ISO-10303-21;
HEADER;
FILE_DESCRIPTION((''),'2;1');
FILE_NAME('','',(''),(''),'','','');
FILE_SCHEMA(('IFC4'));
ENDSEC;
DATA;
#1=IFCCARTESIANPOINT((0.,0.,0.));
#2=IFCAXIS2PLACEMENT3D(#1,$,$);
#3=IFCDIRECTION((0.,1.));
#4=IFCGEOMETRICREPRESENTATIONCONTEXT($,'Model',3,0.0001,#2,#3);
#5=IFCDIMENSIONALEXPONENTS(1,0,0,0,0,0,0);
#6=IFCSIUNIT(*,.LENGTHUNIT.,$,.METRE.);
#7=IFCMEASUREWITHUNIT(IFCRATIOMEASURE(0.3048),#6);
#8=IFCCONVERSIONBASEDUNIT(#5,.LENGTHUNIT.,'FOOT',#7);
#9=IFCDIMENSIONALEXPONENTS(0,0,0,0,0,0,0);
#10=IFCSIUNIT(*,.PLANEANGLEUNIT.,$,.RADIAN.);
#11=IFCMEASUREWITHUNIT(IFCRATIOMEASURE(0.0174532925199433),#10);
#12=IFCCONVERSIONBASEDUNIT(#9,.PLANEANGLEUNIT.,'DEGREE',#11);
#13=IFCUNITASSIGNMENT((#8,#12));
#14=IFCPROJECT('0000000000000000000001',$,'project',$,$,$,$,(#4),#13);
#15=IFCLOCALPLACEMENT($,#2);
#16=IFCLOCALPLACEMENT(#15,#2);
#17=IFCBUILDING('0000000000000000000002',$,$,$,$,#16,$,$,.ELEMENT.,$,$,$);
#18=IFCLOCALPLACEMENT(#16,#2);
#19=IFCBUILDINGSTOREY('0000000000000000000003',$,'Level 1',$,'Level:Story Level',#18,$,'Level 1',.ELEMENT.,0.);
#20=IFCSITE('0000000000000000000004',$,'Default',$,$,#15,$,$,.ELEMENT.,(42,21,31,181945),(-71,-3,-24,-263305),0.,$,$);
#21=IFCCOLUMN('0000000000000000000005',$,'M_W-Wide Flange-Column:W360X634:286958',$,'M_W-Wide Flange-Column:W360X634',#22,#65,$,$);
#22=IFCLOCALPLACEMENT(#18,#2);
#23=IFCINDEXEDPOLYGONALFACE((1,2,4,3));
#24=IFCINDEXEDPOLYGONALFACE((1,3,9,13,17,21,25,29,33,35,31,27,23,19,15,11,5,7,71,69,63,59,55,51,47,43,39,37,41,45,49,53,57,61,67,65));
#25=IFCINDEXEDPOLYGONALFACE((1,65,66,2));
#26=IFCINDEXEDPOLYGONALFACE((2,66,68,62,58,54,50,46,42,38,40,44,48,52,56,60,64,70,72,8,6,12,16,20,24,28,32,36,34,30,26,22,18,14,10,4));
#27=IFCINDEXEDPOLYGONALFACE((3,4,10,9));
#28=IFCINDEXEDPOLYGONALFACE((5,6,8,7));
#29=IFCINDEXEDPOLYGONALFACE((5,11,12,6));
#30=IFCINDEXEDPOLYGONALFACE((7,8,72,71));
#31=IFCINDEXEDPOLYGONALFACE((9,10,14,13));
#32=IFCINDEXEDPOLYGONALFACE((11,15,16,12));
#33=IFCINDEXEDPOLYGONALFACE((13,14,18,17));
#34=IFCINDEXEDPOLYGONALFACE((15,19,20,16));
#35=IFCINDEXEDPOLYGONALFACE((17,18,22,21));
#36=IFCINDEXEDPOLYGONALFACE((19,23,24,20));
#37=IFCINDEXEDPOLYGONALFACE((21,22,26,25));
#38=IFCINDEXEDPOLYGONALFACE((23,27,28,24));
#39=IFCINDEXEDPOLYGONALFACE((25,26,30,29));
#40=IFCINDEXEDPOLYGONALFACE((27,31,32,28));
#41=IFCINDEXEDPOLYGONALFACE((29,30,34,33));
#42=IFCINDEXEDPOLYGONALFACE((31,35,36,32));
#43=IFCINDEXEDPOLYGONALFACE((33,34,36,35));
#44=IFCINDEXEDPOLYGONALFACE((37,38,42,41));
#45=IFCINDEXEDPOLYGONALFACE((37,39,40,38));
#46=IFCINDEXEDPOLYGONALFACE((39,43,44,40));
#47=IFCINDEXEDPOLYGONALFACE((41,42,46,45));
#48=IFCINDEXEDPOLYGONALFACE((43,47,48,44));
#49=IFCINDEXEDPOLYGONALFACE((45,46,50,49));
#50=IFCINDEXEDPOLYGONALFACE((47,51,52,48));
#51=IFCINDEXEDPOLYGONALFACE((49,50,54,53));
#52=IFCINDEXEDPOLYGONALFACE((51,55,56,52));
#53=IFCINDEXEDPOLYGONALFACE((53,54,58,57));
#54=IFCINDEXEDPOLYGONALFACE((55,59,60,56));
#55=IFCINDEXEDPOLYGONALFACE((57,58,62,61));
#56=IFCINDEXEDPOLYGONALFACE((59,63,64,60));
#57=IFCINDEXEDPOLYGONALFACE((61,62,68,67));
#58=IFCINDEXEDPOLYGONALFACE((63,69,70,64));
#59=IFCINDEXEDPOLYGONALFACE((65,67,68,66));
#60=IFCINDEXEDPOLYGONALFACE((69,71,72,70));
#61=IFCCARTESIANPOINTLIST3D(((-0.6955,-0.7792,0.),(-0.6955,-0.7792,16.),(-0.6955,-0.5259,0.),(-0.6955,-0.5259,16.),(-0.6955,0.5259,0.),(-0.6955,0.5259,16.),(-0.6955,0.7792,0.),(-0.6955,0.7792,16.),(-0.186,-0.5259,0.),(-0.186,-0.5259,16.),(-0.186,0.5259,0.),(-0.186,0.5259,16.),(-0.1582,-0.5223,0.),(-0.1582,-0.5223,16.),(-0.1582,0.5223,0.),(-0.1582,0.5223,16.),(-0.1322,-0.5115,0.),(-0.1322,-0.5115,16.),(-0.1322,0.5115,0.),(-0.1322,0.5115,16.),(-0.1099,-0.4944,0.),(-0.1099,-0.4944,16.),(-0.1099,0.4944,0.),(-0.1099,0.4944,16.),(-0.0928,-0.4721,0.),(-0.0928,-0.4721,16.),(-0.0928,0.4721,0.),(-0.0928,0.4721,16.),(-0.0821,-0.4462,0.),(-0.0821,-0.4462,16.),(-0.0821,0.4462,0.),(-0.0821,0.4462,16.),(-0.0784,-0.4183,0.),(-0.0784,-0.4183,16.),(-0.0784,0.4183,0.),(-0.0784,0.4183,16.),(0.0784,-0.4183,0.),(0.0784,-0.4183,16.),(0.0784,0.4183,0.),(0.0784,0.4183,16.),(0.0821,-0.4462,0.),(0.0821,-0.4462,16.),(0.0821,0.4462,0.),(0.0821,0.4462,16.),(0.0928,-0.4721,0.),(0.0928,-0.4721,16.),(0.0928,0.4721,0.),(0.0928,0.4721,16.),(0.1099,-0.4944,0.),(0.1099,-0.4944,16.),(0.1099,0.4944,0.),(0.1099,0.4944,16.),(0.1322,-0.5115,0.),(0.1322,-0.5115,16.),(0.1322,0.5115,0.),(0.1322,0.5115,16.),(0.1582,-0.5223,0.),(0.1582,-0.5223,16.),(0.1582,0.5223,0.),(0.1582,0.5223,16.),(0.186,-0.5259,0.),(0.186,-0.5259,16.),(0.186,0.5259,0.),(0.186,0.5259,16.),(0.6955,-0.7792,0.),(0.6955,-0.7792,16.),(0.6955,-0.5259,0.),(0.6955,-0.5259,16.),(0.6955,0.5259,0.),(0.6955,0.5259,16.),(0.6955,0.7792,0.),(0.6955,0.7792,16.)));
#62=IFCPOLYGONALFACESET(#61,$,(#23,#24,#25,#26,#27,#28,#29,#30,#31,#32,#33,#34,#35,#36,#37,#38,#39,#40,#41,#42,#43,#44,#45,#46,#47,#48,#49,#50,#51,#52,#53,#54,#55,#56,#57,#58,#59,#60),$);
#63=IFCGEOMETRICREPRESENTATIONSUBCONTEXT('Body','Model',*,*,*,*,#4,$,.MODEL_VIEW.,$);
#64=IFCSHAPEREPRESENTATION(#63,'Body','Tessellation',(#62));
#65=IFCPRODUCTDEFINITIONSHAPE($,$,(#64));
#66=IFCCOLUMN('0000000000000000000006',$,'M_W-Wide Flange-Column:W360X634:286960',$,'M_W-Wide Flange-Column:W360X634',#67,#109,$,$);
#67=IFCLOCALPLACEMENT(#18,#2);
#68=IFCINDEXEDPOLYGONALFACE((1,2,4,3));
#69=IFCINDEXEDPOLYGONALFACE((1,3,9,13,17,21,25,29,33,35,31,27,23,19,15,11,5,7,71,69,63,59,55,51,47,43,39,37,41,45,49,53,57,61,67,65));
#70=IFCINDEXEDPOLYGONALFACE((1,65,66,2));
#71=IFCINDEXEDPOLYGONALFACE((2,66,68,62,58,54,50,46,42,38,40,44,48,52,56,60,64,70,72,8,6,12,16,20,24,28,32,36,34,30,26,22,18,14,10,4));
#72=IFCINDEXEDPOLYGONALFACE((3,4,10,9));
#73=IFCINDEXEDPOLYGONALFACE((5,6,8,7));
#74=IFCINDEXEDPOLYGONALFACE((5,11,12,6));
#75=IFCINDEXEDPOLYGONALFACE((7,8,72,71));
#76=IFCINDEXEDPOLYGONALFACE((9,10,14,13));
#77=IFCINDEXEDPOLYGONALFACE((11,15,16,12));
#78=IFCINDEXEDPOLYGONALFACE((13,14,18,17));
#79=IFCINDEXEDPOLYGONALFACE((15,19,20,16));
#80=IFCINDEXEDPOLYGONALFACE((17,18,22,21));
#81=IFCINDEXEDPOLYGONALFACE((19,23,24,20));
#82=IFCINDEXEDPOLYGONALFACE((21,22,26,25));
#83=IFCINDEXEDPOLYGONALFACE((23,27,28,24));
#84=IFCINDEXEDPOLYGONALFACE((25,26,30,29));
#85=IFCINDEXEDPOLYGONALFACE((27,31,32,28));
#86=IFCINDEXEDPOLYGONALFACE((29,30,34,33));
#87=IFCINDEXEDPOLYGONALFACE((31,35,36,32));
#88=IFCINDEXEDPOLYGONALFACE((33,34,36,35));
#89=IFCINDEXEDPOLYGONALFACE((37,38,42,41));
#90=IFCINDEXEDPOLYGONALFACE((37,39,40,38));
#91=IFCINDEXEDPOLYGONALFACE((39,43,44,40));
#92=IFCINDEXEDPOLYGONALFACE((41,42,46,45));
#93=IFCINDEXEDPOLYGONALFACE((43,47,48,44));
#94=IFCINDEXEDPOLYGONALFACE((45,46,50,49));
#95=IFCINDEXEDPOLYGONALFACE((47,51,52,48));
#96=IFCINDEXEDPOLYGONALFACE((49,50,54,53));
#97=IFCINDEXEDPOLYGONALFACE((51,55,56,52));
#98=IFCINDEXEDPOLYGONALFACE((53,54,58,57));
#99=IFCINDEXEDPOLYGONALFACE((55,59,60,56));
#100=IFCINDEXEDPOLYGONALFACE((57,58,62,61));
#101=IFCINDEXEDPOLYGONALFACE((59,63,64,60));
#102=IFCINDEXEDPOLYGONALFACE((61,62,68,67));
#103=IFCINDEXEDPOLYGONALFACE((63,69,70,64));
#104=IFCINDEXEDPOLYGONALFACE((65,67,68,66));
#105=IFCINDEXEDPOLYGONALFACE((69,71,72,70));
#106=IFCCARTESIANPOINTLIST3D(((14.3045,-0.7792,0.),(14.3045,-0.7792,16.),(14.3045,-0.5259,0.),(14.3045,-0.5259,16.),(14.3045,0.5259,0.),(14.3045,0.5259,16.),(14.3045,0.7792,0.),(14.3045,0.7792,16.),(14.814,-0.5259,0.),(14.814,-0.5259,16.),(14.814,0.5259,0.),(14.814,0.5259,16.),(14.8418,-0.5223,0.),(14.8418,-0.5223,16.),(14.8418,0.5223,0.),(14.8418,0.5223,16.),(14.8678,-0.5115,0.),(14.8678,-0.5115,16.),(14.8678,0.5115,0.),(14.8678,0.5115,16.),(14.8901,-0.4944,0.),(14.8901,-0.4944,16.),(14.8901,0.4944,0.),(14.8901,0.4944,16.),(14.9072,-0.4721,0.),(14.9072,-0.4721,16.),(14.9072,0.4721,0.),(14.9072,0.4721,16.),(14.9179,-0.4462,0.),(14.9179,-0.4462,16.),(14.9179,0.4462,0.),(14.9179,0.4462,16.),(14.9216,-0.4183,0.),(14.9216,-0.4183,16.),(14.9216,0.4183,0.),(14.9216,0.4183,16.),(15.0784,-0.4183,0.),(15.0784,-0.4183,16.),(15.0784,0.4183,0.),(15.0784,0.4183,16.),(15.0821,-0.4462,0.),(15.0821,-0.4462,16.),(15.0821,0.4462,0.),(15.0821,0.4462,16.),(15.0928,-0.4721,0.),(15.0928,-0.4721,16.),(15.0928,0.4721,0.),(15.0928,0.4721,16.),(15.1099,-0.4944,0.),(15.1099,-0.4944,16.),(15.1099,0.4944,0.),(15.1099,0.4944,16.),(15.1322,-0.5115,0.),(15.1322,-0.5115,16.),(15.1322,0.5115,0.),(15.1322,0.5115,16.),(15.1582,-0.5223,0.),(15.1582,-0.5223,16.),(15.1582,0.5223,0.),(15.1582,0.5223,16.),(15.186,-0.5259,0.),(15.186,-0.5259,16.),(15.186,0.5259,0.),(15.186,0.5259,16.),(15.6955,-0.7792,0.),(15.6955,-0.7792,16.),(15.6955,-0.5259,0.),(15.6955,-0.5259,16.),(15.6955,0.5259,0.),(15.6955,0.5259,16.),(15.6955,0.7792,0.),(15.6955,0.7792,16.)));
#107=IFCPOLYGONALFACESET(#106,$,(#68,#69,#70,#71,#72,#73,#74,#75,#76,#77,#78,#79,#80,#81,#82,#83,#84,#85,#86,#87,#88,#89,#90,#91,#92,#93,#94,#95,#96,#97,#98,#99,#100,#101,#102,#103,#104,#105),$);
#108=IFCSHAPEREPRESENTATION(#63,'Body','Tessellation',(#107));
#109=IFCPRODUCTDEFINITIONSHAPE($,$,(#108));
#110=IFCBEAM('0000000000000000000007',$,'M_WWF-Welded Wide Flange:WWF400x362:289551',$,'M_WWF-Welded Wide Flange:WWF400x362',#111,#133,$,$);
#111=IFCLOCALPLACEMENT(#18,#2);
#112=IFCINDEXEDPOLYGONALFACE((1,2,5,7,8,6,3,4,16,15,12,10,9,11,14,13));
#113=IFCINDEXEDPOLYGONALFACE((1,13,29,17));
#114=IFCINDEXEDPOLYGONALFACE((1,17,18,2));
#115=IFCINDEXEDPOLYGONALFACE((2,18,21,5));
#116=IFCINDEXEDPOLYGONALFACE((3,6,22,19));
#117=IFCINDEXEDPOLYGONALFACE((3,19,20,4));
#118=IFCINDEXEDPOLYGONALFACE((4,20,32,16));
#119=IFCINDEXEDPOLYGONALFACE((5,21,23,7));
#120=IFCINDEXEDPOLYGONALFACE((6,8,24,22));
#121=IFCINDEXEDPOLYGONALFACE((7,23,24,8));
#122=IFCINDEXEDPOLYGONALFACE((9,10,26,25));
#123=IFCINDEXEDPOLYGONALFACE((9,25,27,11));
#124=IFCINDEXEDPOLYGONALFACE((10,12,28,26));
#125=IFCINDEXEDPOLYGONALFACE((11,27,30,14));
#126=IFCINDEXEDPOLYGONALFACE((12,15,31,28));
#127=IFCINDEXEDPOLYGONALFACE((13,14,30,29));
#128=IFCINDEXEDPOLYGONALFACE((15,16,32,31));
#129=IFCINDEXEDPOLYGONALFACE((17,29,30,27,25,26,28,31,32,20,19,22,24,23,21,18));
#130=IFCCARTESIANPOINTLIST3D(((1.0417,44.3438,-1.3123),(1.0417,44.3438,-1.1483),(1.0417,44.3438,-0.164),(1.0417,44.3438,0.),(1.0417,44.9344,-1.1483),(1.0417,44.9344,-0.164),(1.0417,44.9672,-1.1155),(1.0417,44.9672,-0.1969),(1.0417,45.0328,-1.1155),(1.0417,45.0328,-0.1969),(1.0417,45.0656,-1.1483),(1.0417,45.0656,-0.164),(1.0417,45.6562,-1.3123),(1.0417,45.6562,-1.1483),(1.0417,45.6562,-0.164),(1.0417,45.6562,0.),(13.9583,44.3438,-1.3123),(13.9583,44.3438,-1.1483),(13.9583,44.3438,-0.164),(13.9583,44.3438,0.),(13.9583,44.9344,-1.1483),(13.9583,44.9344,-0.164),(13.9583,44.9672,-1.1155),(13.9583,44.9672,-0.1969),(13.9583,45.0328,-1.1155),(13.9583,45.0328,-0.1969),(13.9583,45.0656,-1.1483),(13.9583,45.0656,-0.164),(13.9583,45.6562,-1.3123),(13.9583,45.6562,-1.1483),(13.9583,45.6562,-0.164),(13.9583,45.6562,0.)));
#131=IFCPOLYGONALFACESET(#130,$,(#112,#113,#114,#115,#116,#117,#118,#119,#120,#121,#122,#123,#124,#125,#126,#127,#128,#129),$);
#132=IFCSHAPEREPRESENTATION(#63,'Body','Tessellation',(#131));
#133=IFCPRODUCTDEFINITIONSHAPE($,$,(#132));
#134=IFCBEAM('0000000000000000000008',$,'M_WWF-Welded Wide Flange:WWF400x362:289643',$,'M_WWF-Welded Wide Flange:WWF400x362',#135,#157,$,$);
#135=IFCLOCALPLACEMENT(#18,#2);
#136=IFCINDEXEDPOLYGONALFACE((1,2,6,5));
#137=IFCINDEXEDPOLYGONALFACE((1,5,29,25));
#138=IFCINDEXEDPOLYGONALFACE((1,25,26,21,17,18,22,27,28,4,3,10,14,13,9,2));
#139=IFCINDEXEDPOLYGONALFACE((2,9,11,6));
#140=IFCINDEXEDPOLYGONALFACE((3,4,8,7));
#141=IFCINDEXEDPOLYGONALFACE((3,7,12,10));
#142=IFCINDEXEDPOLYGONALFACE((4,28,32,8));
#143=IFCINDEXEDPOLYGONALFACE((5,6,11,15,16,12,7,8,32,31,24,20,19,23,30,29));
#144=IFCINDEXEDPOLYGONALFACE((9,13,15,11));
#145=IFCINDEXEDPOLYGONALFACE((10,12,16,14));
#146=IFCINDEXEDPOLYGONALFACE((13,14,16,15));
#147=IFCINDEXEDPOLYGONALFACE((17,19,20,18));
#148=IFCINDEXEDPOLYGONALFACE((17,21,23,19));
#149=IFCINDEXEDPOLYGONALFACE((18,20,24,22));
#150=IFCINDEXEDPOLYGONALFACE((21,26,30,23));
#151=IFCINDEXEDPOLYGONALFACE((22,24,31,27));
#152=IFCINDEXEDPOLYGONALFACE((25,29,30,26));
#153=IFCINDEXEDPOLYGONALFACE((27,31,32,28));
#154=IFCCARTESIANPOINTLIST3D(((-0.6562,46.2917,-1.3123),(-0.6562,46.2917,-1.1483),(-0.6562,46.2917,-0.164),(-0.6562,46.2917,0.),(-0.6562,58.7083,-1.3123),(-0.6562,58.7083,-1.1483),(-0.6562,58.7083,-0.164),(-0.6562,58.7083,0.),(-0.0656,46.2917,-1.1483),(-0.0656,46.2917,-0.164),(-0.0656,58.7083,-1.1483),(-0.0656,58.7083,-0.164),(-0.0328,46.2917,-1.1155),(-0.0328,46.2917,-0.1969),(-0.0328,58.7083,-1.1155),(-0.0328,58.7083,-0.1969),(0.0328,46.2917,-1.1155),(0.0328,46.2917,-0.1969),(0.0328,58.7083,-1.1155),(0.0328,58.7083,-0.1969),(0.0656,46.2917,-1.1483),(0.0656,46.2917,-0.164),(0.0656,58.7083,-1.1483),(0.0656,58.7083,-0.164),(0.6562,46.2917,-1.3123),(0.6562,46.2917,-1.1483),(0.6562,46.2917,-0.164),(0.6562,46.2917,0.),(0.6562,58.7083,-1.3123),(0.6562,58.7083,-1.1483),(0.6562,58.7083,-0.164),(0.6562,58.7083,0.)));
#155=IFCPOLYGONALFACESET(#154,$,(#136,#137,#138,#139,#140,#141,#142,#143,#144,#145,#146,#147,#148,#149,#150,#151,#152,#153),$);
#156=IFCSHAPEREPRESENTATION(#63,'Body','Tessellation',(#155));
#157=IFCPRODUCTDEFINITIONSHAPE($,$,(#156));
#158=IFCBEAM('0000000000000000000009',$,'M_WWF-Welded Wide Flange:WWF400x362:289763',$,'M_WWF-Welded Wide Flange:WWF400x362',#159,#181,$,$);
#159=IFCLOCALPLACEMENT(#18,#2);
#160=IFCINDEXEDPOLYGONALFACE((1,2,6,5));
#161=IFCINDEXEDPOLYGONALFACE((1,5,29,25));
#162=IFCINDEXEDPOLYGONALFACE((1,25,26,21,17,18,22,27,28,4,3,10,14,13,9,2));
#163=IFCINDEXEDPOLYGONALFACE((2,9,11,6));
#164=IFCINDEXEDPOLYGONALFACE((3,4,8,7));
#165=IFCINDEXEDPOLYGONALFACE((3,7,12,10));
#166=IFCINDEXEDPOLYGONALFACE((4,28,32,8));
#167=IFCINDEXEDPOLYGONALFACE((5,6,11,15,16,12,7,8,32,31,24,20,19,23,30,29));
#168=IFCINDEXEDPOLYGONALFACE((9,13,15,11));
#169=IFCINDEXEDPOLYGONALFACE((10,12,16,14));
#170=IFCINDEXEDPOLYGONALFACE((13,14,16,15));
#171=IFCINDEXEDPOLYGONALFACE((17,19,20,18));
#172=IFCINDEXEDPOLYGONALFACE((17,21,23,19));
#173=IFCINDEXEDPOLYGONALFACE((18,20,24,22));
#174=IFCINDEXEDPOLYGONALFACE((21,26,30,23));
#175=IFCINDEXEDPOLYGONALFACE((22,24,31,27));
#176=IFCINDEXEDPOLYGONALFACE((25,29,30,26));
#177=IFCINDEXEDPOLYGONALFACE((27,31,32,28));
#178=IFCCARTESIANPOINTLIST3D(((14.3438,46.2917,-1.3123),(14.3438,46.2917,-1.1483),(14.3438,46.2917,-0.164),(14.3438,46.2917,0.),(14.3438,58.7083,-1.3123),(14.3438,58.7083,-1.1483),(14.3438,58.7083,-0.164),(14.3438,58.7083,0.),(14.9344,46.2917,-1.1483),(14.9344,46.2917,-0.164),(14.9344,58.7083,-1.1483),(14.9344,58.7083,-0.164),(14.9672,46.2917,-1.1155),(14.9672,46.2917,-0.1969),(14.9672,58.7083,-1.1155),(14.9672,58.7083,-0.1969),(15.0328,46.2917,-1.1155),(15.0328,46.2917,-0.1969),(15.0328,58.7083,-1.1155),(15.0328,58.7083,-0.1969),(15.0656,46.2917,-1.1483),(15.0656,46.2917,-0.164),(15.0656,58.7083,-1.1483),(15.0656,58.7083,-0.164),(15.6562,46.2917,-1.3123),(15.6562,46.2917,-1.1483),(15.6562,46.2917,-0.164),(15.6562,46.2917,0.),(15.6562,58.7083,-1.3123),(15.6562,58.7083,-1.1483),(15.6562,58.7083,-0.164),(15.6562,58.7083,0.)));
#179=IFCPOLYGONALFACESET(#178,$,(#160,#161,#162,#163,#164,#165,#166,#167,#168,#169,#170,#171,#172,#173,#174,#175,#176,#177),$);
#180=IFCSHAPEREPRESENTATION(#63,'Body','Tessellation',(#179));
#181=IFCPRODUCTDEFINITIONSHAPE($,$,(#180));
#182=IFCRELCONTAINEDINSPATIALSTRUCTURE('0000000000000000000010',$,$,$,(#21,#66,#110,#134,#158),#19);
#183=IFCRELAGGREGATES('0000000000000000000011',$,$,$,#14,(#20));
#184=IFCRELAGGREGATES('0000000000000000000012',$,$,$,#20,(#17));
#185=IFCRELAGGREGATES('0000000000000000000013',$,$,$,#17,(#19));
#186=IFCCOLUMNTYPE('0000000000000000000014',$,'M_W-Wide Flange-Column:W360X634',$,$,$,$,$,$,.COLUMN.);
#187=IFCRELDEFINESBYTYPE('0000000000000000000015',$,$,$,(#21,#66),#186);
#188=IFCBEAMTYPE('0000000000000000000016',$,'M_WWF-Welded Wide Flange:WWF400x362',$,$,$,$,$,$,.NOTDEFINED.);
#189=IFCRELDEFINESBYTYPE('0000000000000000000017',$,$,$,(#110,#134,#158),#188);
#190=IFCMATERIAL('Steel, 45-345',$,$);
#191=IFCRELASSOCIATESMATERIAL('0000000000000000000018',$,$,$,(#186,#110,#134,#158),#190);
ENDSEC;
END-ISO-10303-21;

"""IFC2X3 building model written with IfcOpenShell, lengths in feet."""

from ifc_helpers import new_model, entity, si_unit, converted_unit, direction, frame, frame_2d, origin, place, context, subcontext, project, spatial, polyline, circle_curve, parameter, trimmed, segment, composite_curve, outline, extrude, source, transform, mapped, material, type_object, type_shapes, element, save


model = new_model("IFC2X3")

# Units and contexts
model_context = context("Model", 3, precision=0.0001, world=origin(), true_north=direction((0.0, 1.0)))
body_context = subcontext(model_context, "Body", "Model", "MODEL_VIEW")
ifc_project = project(units=[converted_unit("LENGTHUNIT", "FOOT", entity("IfcRatioMeasure", 0.3048), si_unit("LENGTHUNIT", "METRE"), dimensions=[1, 0, 0, 0, 0, 0, 0]), converted_unit("PLANEANGLEUNIT", "DEGREE", entity("IfcRatioMeasure", 0.0174532925199433), si_unit("PLANEANGLEUNIT", "RADIAN"), dimensions=[0, 0, 0, 0, 0, 0, 0])], contexts=[model_context])

# Site, building, storey
site_placement = place(None, origin())
site = spatial("IfcSite", under=ifc_project, at=site_placement, Name="Default", CompositionType="ELEMENT", RefLatitude=(42, 21, 31, 181945), RefLongitude=(-71, -3, -24, -263305), RefElevation=0.0)
building_placement = place(site_placement, origin())
building = spatial("IfcBuilding", under=site, at=building_placement, CompositionType="ELEMENT")
storey_placement = place(building_placement, origin())
storey = spatial("IfcBuildingStorey", under=building, at=storey_placement, Name="Level 1", ObjectType="Level:Story Level", LongName="Level 1", CompositionType="ELEMENT", Elevation=0.0)

# Columns
ifc_material = material(Name="Steel, 45-345")
column_type = type_object("IfcColumnType", Name="M_W-Wide Flange-Column:W360X634", PredefinedType="COLUMN", material=ifc_material)
shared_shape = source(origin(), body_context, "Body", "SweptSolid", [
    extrude(outline(composite_curve([segment(polyline([(0.5259, -0.6955), (0.7792, -0.6955)]), True, "CONTINUOUS"), segment(polyline([(0.7792, -0.6955), (0.7792, 0.6955)]), True, "CONTINUOUS"), segment(polyline([(0.7792, 0.6955), (0.5259, 0.6955)]), True, "CONTINUOUS"), segment(polyline([(0.5259, 0.6955), (0.5259, 0.186)]), True, "CONTINUOUS"), segment(trimmed(circle_curve(frame_2d((0.4183, 0.186), x_axis=(1.0, 0.0)), 0.1076), [parameter(270.0)], [parameter(0.0)], True, "PARAMETER"), False, "CONTINUOUS"), segment(polyline([(0.4183, 0.0784), (-0.4183, 0.0784)]), True, "CONTINUOUS"), segment(trimmed(circle_curve(frame_2d((-0.4183, 0.186), x_axis=(0.0, -1.0)), 0.1076), [parameter(270.0)], [parameter(0.0)], True, "PARAMETER"), False, "CONTINUOUS"), segment(polyline([(-0.5259, 0.186), (-0.5259, 0.6955)]), True, "CONTINUOUS"), segment(polyline([(-0.5259, 0.6955), (-0.7792, 0.6955)]), True, "CONTINUOUS"), segment(polyline([(-0.7792, 0.6955), (-0.7792, -0.6955)]), True, "CONTINUOUS"), segment(polyline([(-0.7792, -0.6955), (-0.5259, -0.6955)]), True, "CONTINUOUS"), segment(polyline([(-0.5259, -0.6955), (-0.5259, -0.186)]), True, "CONTINUOUS"), segment(trimmed(circle_curve(frame_2d((-0.4183, -0.186), x_axis=(-1.0, 0.0)), 0.1076), [parameter(270.0)], [parameter(0.0)], True, "PARAMETER"), False, "CONTINUOUS"), segment(polyline([(-0.4183, -0.0784), (0.4183, -0.0784)]), True, "CONTINUOUS"), segment(trimmed(circle_curve(frame_2d((0.4183, -0.186), x_axis=(0.0, 1.0)), 0.1076), [parameter(270.0)], [parameter(0.0)], True, "PARAMETER"), False, "CONTINUOUS"), segment(polyline([(0.5259, -0.186), (0.5259, -0.6955)]), True, "CONTINUOUS")], self_intersect=False)), frame((0.0, 0.0, 0.0), z_axis=(0.0, 0.0, 1.0), x_axis=(0.0, -1.0, 0.0)), (0.0, 0.0, 1.0), 16.0),
])
type_shapes(column_type, [shared_shape])
for number, where, name in (
    (1, (0.0, 0.0, 0.0), "M_W-Wide Flange-Column:W360X634:286958"),
    (2, (15.0, 0.0, 0.0), "M_W-Wide Flange-Column:W360X634:286960"),
):
    element("IfcColumn", number, at=place(storey_placement, frame(where)), inside=storey, type_object=column_type, Name=name, ObjectType="M_W-Wide Flange-Column:W360X634", context=body_context, shape_type="MappedRepresentation", body=[
        mapped(shared_shape, transform((0.0, 0.0, 0.0), scale=1.0)),
    ])

# Beams
beam_type = type_object("IfcBeamType", Name="M_WWF-Welded Wide Flange:WWF400x362", PredefinedType="NOTDEFINED")
beam_1_placement = place(storey_placement, frame((0.0, 45.0, 0.0)))
element("IfcBeam", 3, at=beam_1_placement, inside=storey, type_object=beam_type, material=ifc_material, Name="M_WWF-Welded Wide Flange:WWF400x362:289551", ObjectType="M_WWF-Welded Wide Flange:WWF400x362", context=body_context, shape_type="SweptSolid", body=[
    extrude(outline(polyline([(-0.6562, -0.6562), (-0.4921, -0.6562), (-0.4921, -0.0656), (-0.4593, -0.0328), (0.4593, -0.0328), (0.4921, -0.0656), (0.4921, -0.6562), (0.6562, -0.6562), (0.6562, 0.6562), (0.4921, 0.6562), (0.4921, 0.0656), (0.4593, 0.0328), (-0.4593, 0.0328), (-0.4921, 0.0656), (-0.4921, 0.6562), (-0.6562, 0.6562), (-0.6562, -0.6562)])), frame((1.0417, 0.0, -0.6562), z_axis=(1.0, 0.0, 0.0), x_axis=(0.0, 0.0, -1.0)), (0.0, 0.0, 1.0), 12.9167),
])
beam_2_placement = place(storey_placement, frame((0.0, 45.0, 0.0), z_axis=(0.0, 0.0, 1.0), x_axis=(0.0, 1.0, 0.0)))
element("IfcBeam", 4, at=beam_2_placement, inside=storey, type_object=beam_type, material=ifc_material, Name="M_WWF-Welded Wide Flange:WWF400x362:289643", ObjectType="M_WWF-Welded Wide Flange:WWF400x362", context=body_context, shape_type="SweptSolid", body=[
    extrude(outline(polyline([(-0.6562, -0.6562), (-0.4921, -0.6562), (-0.4921, -0.0656), (-0.4593, -0.0328), (0.4593, -0.0328), (0.4921, -0.0656), (0.4921, -0.6562), (0.6562, -0.6562), (0.6562, 0.6562), (0.4921, 0.6562), (0.4921, 0.0656), (0.4593, 0.0328), (-0.4593, 0.0328), (-0.4921, 0.0656), (-0.4921, 0.6562), (-0.6562, 0.6562), (-0.6562, -0.6562)])), frame((1.2917, 0.0, -0.6562), z_axis=(1.0, 0.0, 0.0), x_axis=(0.0, 0.0, -1.0)), (0.0, 0.0, 1.0), 12.4167),
])
beam_3_placement = place(storey_placement, frame((15.0, 45.0, 0.0), z_axis=(0.0, 0.0, 1.0), x_axis=(0.0, 1.0, 0.0)))
element("IfcBeam", 5, at=beam_3_placement, inside=storey, type_object=beam_type, material=ifc_material, Name="M_WWF-Welded Wide Flange:WWF400x362:289763", ObjectType="M_WWF-Welded Wide Flange:WWF400x362", context=body_context, shape_type="SweptSolid", body=[
    extrude(outline(polyline([(-0.6562, -0.6562), (-0.4921, -0.6562), (-0.4921, -0.0656), (-0.4593, -0.0328), (0.4593, -0.0328), (0.4921, -0.0656), (0.4921, -0.6562), (0.6562, -0.6562), (0.6562, 0.6562), (0.4921, 0.6562), (0.4921, 0.0656), (0.4593, 0.0328), (-0.4593, 0.0328), (-0.4921, 0.0656), (-0.4921, 0.6562), (-0.6562, 0.6562), (-0.6562, -0.6562)])), frame((1.2917, 0.0, -0.6562), z_axis=(1.0, 0.0, 0.0), x_axis=(0.0, 0.0, -1.0)), (0.0, 0.0, 1.0), 12.4167),
])

save(model, "model.ifc")
